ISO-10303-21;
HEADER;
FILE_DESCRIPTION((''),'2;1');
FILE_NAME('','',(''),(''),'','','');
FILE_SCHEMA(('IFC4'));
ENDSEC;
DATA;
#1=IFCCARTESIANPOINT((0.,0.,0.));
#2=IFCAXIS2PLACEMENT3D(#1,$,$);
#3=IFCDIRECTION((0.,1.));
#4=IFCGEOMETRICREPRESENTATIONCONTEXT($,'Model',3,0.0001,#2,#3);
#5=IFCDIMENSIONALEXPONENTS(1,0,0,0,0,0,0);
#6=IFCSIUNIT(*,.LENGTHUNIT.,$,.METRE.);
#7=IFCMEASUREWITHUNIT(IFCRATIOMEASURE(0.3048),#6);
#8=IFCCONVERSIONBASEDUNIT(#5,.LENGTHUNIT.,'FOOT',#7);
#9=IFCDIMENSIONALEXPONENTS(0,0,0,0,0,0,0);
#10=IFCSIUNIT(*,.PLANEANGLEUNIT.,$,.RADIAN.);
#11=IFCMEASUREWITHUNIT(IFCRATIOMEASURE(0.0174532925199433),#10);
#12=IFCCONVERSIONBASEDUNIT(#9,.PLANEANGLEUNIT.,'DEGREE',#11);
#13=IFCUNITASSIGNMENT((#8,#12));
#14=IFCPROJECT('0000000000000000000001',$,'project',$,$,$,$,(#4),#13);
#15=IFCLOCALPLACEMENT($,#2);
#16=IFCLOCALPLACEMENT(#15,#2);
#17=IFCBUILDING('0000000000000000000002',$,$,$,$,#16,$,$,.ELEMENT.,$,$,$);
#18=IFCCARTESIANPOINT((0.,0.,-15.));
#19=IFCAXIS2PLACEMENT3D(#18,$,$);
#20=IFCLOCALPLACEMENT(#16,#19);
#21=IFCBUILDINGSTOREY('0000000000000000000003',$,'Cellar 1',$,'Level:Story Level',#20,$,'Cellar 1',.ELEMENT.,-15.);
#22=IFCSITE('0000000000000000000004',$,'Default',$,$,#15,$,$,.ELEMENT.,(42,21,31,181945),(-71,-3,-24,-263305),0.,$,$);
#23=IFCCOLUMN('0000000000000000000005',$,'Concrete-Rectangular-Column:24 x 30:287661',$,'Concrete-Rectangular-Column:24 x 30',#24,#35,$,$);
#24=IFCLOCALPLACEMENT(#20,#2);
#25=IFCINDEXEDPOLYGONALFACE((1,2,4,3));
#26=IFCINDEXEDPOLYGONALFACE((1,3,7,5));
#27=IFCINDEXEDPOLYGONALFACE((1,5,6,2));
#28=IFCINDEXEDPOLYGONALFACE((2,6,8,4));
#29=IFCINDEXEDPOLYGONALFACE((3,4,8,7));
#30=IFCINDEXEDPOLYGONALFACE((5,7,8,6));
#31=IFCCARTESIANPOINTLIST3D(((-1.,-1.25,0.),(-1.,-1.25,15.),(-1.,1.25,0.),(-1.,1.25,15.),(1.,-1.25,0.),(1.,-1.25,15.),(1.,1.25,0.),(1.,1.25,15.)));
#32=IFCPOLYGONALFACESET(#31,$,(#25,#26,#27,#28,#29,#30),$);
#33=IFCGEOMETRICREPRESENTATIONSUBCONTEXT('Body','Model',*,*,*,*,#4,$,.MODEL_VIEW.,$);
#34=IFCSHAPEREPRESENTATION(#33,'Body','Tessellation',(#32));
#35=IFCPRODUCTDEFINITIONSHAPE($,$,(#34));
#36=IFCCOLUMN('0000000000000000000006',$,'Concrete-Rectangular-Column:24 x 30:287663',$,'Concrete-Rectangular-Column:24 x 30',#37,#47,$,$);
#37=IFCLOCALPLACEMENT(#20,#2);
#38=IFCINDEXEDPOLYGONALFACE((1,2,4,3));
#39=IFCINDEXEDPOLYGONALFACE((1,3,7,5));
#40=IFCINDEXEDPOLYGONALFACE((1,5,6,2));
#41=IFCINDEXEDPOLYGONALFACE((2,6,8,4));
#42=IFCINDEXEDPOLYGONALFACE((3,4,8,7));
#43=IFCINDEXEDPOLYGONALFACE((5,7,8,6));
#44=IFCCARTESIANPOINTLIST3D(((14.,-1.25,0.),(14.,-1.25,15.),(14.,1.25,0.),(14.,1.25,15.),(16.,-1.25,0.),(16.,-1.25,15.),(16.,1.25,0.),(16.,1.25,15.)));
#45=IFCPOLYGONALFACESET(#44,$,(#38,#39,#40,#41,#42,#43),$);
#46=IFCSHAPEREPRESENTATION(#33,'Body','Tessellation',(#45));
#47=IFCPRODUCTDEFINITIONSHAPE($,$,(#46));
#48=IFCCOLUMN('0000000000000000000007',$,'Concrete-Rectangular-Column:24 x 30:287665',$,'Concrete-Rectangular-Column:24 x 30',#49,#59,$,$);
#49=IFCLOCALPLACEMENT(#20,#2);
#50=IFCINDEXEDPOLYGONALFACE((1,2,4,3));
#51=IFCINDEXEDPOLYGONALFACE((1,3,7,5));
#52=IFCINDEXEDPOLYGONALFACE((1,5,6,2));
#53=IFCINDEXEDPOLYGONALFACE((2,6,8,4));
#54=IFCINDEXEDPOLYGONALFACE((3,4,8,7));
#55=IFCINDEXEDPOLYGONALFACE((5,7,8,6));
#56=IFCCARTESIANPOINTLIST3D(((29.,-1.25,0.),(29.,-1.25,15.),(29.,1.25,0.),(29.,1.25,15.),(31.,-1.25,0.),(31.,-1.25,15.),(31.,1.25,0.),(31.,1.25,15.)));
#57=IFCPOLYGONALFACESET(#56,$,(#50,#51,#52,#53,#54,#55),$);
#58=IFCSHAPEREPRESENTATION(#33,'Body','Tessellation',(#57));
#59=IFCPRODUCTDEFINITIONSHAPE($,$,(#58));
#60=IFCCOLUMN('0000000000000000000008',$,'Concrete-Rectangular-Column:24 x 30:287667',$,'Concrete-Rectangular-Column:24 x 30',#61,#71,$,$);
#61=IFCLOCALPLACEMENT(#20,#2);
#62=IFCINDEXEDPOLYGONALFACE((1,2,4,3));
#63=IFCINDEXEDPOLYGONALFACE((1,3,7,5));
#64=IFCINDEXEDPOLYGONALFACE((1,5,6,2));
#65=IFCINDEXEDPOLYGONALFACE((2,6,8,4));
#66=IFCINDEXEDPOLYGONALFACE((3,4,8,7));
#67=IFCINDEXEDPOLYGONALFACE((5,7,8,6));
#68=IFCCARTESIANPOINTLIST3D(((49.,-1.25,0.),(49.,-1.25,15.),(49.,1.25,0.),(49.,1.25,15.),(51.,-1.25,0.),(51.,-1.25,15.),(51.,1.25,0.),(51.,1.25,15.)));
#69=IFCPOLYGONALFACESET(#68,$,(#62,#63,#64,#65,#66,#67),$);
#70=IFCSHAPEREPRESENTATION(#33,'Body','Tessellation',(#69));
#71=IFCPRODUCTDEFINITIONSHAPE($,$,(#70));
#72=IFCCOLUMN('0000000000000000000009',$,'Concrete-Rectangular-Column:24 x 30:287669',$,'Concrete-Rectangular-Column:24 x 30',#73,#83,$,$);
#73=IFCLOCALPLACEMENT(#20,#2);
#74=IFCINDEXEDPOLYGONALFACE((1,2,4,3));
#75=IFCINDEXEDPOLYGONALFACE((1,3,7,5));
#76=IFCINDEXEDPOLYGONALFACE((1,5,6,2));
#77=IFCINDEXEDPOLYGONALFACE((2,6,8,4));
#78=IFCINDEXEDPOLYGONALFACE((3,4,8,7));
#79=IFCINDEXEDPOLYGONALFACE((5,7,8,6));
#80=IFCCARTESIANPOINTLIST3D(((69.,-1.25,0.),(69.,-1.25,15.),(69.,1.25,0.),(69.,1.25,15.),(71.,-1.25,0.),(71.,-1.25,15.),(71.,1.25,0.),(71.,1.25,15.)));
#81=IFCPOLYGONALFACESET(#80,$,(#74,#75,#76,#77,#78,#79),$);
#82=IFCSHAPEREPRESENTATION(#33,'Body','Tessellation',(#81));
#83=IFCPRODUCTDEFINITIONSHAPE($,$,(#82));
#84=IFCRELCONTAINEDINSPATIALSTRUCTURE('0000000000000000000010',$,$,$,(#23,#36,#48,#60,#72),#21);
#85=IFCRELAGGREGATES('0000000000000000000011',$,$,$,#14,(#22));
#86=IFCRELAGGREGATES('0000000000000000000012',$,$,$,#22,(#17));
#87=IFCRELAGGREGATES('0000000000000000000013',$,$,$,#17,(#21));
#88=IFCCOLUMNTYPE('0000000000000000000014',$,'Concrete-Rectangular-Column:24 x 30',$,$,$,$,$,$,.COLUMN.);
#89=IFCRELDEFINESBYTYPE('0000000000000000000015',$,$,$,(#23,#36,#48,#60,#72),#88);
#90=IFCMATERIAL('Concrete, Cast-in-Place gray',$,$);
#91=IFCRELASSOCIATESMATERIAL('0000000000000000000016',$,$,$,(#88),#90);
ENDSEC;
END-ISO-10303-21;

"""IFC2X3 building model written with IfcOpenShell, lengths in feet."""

from ifc_helpers import new_model, entity, si_unit, converted_unit, direction, frame, origin, origin_2d_with_axis, place, context, subcontext, project, spatial, rectangle, extrude, source, transform, mapped, material, type_object, type_shapes, element, save


model = new_model("IFC2X3")

# Units and contexts
model_context = context("Model", 3, precision=0.0001, world=origin(), true_north=direction((0.0, 1.0)))
body_context = subcontext(model_context, "Body", "Model", "MODEL_VIEW")
ifc_project = project(units=[converted_unit("LENGTHUNIT", "FOOT", entity("IfcRatioMeasure", 0.3048), si_unit("LENGTHUNIT", "METRE"), dimensions=[1, 0, 0, 0, 0, 0, 0]), converted_unit("PLANEANGLEUNIT", "DEGREE", entity("IfcRatioMeasure", 0.0174532925199433), si_unit("PLANEANGLEUNIT", "RADIAN"), dimensions=[0, 0, 0, 0, 0, 0, 0])], contexts=[model_context])

# Site, building, storey
site_placement = place(None, origin())
site = spatial("IfcSite", under=ifc_project, at=site_placement, Name="Default", CompositionType="ELEMENT", RefLatitude=(42, 21, 31, 181945), RefLongitude=(-71, -3, -24, -263305), RefElevation=0.0)
building_placement = place(site_placement, origin())
building = spatial("IfcBuilding", under=site, at=building_placement, CompositionType="ELEMENT")
storey_placement = place(building_placement, frame((0.0, 0.0, -15.0)))
storey = spatial("IfcBuildingStorey", under=building, at=storey_placement, Name="Cellar 1", ObjectType="Level:Story Level", LongName="Cellar 1", CompositionType="ELEMENT", Elevation=-15.0)

# Columns
ifc_material = material(Name="Concrete, Cast-in-Place gray")
column_type = type_object("IfcColumnType", Name="Concrete-Rectangular-Column:24 x 30", PredefinedType="COLUMN", material=ifc_material)
shared_shape = source(origin(), body_context, "Body", "SweptSolid", [
    extrude(rectangle(XDim=2.5, YDim=2.0, at=origin_2d_with_axis()), frame((0.0, 0.0, -15.0), z_axis=(0.0, 0.0, 1.0), x_axis=(0.0, -1.0, 0.0)), (0.0, 0.0, 1.0), 15.0),
])
type_shapes(column_type, [shared_shape])
for number, where, name in (
    (1, (0.0, 0.0, 15.0), "Concrete-Rectangular-Column:24 x 30:287661"),
    (2, (15.0, 0.0, 15.0), "Concrete-Rectangular-Column:24 x 30:287663"),
    (3, (30.0, 0.0, 15.0), "Concrete-Rectangular-Column:24 x 30:287665"),
    (4, (50.0, 0.0, 15.0), "Concrete-Rectangular-Column:24 x 30:287667"),
    (5, (70.0, 0.0, 15.0), "Concrete-Rectangular-Column:24 x 30:287669"),
):
    element("IfcColumn", number, at=place(storey_placement, frame(where)), inside=storey, type_object=column_type, Name=name, ObjectType="Concrete-Rectangular-Column:24 x 30", context=body_context, shape_type="MappedRepresentation", body=[
        mapped(shared_shape, transform((0.0, 0.0, 0.0), scale=1.0)),
    ])

save(model, "model.ifc")
